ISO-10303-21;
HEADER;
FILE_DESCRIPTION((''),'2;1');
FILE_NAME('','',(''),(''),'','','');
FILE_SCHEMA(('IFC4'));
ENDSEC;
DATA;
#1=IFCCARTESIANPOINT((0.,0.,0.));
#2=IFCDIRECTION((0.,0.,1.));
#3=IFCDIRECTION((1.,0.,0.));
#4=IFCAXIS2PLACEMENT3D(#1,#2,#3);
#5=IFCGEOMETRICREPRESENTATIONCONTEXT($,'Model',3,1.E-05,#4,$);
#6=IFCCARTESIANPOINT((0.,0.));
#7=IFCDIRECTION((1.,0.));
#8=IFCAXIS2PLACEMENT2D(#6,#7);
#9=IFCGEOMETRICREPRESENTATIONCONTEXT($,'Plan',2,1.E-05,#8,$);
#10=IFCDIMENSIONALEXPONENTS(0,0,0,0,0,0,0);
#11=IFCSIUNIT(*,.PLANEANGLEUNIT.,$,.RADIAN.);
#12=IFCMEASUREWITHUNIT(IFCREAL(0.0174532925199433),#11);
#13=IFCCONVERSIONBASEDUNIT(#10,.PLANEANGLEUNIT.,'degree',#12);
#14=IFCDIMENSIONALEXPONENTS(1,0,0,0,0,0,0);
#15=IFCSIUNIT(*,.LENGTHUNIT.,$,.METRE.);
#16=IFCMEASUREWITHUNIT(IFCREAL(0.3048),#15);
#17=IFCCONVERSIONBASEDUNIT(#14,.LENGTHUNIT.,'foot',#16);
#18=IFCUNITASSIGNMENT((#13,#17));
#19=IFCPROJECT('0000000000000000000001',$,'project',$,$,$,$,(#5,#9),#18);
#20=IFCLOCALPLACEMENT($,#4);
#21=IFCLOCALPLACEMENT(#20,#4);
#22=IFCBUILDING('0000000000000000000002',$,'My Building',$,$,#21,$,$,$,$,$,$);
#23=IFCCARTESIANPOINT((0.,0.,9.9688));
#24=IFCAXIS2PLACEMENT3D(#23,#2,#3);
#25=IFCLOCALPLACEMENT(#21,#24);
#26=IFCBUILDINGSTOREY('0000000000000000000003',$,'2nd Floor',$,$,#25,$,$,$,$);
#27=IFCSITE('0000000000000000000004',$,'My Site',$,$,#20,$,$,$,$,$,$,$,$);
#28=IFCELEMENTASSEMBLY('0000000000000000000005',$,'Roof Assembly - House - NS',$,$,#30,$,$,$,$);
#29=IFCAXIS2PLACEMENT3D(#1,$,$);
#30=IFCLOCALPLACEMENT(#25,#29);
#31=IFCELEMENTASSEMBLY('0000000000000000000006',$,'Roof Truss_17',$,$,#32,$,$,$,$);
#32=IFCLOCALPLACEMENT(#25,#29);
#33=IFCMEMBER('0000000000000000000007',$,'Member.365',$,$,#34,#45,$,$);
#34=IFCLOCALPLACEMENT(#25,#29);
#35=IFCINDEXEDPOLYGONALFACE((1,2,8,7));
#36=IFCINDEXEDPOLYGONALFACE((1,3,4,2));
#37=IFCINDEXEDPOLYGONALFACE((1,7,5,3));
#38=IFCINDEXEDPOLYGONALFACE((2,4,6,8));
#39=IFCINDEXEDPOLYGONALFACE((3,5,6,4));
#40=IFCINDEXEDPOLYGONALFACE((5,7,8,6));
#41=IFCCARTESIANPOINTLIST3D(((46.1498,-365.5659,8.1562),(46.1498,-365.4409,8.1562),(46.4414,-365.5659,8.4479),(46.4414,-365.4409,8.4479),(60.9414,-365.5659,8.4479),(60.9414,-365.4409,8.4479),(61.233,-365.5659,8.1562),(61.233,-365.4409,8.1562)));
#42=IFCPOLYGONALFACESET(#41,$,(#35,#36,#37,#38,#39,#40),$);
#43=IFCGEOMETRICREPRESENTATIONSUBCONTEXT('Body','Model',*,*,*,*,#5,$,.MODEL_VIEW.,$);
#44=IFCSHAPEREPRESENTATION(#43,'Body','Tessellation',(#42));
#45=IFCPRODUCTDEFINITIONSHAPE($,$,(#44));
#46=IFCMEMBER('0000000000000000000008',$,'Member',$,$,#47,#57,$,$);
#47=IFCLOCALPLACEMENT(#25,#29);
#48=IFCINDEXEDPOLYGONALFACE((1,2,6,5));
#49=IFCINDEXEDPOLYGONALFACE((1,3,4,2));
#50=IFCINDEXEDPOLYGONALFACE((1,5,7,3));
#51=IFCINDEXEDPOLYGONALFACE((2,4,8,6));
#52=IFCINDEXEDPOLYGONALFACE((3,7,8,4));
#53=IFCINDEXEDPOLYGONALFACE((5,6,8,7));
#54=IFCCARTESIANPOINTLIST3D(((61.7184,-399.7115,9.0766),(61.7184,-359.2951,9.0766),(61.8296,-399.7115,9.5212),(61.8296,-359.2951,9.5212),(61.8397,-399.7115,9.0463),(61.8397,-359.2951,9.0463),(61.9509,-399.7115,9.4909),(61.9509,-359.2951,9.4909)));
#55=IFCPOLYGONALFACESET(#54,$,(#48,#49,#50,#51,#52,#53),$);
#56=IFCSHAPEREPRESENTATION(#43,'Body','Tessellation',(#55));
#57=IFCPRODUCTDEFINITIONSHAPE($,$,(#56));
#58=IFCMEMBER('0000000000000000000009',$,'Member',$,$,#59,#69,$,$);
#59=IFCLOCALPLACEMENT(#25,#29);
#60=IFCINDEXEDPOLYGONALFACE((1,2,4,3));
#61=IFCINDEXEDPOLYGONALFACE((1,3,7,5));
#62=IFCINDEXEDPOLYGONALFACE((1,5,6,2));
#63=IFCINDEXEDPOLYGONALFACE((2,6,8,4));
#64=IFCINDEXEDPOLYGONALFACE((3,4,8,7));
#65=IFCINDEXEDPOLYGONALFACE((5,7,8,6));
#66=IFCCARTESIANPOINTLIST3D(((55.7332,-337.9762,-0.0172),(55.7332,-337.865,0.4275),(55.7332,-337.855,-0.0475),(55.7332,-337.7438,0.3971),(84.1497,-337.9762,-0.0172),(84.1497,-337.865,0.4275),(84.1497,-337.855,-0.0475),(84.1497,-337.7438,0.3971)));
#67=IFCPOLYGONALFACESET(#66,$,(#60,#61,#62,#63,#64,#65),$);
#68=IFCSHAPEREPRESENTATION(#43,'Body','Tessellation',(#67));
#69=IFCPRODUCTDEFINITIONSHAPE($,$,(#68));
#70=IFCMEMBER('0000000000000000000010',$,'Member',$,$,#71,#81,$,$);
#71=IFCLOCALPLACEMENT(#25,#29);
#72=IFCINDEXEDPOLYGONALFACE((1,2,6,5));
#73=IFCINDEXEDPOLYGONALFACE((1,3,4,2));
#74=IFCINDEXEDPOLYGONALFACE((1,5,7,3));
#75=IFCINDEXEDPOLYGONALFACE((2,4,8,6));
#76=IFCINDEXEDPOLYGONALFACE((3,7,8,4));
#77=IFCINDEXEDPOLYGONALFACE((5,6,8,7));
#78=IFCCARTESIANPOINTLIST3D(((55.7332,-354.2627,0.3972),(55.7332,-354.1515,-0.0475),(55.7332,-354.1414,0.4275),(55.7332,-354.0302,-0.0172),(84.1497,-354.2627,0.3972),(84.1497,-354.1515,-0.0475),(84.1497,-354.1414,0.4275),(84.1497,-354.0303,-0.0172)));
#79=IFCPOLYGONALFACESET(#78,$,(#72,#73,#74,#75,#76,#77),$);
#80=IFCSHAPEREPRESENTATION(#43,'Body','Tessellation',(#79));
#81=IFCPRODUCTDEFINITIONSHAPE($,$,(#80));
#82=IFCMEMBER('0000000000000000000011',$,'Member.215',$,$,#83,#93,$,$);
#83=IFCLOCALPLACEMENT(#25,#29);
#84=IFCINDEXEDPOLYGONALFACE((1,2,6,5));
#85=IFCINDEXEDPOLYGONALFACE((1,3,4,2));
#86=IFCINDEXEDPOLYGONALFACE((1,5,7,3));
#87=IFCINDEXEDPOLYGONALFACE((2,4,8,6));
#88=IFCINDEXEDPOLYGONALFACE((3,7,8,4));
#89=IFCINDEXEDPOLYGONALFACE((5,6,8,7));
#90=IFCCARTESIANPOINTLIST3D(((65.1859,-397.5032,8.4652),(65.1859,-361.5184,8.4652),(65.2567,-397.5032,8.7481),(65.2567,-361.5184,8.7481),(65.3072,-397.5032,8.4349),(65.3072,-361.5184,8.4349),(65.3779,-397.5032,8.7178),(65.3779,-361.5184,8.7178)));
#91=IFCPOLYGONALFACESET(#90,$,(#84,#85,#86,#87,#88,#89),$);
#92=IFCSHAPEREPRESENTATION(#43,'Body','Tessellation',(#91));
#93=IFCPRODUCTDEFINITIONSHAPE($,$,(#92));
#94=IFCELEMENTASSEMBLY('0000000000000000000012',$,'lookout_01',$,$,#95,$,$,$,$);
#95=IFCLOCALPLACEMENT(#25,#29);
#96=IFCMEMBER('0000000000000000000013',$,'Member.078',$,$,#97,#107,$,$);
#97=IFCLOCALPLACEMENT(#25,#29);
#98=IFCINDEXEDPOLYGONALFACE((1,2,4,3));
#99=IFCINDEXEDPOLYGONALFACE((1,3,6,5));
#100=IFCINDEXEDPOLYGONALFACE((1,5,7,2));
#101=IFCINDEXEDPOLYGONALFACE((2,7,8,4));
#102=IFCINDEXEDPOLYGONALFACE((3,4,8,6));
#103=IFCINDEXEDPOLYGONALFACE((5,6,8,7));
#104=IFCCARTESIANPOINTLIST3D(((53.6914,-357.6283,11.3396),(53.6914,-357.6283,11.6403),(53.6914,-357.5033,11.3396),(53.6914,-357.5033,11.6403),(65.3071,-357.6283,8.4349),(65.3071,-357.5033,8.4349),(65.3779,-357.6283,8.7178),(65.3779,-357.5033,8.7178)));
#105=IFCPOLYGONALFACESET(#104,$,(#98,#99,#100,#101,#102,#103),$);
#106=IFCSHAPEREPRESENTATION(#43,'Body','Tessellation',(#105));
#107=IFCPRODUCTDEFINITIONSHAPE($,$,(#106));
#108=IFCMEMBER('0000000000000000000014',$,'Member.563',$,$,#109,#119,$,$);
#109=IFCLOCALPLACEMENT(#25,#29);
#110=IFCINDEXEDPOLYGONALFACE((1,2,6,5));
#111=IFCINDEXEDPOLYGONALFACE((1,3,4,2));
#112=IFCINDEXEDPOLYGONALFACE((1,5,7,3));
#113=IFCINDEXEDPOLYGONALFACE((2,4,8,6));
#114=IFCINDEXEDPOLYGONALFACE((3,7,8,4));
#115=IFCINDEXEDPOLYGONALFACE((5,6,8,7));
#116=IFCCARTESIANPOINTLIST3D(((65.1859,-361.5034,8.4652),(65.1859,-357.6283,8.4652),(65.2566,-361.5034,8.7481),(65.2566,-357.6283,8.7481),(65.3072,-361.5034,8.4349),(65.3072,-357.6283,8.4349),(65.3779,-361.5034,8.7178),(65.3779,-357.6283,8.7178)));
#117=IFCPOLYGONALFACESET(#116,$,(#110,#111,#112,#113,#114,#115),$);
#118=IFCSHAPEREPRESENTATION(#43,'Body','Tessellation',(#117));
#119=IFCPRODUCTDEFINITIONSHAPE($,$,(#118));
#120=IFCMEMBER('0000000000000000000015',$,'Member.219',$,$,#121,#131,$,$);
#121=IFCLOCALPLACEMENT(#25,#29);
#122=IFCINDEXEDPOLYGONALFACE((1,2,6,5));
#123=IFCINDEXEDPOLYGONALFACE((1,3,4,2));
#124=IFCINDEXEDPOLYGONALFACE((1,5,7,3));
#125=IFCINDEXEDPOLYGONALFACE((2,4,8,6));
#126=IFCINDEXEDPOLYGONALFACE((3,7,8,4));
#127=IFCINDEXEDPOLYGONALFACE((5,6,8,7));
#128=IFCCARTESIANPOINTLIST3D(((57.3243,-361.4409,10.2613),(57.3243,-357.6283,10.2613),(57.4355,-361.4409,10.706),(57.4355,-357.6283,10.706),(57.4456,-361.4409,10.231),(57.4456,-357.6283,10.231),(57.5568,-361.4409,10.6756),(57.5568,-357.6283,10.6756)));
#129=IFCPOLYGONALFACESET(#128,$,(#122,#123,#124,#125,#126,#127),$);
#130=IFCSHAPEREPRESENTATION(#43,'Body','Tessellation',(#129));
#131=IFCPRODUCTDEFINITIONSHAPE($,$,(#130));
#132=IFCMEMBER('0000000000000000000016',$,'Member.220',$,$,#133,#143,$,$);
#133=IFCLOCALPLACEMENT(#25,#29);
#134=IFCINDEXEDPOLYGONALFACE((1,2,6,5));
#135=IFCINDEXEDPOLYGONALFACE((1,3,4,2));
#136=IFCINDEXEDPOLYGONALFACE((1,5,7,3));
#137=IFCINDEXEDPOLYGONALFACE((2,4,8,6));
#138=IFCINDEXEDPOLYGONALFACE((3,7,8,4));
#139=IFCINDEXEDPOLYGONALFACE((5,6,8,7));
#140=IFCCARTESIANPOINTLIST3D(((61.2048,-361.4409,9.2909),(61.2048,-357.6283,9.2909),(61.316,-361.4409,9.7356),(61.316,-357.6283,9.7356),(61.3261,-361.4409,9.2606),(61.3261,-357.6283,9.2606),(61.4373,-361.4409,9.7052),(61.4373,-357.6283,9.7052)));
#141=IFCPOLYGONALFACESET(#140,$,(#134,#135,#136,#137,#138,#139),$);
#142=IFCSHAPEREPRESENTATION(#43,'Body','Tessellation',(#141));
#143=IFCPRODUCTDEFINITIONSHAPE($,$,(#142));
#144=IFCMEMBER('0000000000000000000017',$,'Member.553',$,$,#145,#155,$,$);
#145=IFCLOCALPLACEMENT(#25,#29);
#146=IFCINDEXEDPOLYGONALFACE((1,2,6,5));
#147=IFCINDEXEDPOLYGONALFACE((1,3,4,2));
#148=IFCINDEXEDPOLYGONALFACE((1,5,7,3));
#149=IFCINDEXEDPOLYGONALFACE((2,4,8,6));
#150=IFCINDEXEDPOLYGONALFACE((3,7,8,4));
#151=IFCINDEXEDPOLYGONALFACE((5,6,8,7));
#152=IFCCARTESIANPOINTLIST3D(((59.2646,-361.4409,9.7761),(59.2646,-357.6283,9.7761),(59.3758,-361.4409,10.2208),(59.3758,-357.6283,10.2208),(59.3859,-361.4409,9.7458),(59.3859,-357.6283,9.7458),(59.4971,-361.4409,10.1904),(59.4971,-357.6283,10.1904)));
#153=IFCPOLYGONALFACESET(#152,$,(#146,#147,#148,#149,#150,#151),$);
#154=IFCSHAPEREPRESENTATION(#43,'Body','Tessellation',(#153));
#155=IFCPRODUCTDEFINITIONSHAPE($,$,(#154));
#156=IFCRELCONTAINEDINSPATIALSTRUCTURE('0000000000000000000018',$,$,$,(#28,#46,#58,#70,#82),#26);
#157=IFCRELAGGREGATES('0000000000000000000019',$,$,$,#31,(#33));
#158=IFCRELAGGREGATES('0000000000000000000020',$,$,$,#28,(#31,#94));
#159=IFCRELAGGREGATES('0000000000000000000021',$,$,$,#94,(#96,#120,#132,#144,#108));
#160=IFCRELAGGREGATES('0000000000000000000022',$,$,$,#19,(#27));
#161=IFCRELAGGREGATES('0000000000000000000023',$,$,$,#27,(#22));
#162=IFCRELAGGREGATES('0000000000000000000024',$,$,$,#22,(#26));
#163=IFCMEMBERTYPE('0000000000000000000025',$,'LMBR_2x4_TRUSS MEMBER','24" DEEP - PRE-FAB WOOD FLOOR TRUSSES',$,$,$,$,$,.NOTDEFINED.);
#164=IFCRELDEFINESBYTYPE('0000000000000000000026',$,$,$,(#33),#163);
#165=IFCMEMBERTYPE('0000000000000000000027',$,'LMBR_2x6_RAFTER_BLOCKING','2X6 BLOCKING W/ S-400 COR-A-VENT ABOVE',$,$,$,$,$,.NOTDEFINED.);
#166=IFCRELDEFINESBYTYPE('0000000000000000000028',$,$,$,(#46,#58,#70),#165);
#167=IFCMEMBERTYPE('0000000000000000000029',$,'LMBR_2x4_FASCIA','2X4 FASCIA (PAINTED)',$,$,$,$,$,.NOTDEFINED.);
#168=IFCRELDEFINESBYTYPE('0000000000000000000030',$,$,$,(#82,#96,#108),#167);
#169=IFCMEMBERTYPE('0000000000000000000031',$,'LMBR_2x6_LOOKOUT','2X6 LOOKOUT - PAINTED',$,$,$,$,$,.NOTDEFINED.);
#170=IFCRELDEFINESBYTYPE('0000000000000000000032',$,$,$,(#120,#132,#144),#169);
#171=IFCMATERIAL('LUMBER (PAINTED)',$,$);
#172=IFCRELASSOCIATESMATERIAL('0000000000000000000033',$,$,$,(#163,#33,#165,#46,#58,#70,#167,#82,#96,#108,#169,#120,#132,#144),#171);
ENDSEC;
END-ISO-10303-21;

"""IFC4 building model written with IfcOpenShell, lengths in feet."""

from ifc_helpers import new_model, entity, si_unit, converted_unit, frame, origin_with_axes, origin_2d_with_axis, place, context, subcontext, project, spatial, indexed_curve, outline, extrude, clip, halfspace, material, material_profile, profile_set, profile_usage, type_object, element, aggregate, save


model = new_model("IFC4")

# Units and contexts
model_context = context("Model", 3, precision=1e-05, world=origin_with_axes())
plan_context = context("Plan", 2, precision=1e-05, world=origin_2d_with_axis())
body_context = subcontext(model_context, "Body", "Model", "MODEL_VIEW")
ifc_project = project(units=[converted_unit("PLANEANGLEUNIT", "degree", entity("IfcReal", 0.0174532925199433), si_unit("PLANEANGLEUNIT", "RADIAN"), dimensions=[0, 0, 0, 0, 0, 0, 0]), converted_unit("LENGTHUNIT", "foot", entity("IfcReal", 0.3048), si_unit("LENGTHUNIT", "METRE"), dimensions=[1, 0, 0, 0, 0, 0, 0])], contexts=[model_context, plan_context])

# Site, building, storey
site_placement = place(None, origin_with_axes())
site = spatial("IfcSite", under=ifc_project, at=site_placement, Name="My Site")
building_placement = place(site_placement, origin_with_axes())
building = spatial("IfcBuilding", under=site, at=building_placement, Name="My Building")
storey_placement = place(building_placement, frame((0.0, 0.0, 9.9688), z_axis=(0.0, 0.0, 1.0), x_axis=(1.0, 0.0, 0.0)))
storey = spatial("IfcBuildingStorey", under=building, at=storey_placement, Name="2nd Floor")

# Shared definitions
ifc_material_1 = material(Name="LUMBER (PAINTED)")

# Element assemblies, member
assembly_1_placement = place(storey_placement, frame((0.0, 0.0, -9.9688), z_axis=(0.0, 0.0, 1.0), x_axis=(1.0, 0.0, 0.0)))
assembly_1 = element("IfcElementAssembly", 1, at=assembly_1_placement, inside=storey, Name="Roof Assembly - House - NS")
ifc_material_profile_1 = material_profile(ifc_material_1, outline(indexed_curve([(-0.0625, -0.1458), (0.0625, -0.1458), (0.0625, 0.1458), (-0.0625, 0.1458), (-0.0625, -0.1458)])))
ifc_profile_set_1 = profile_set([ifc_material_profile_1])
member_type_1 = type_object("IfcMemberType", Name="LMBR_2x4_TRUSS MEMBER", Description="24\" DEEP - PRE-FAB WOOD FLOOR TRUSSES", PredefinedType="NOTDEFINED", material=ifc_profile_set_1)
assembly_2_placement = place(assembly_1_placement, frame((53.6914, -365.5034, 21.6754), z_axis=(0.0, 0.0, 1.0), x_axis=(1.0, 0.0, 0.0)))
assembly_2 = element("IfcElementAssembly", 2, at=assembly_2_placement, Name="Roof Truss_17")
ifc_profile_usage_1 = profile_usage(ifc_profile_set_1)
member_1_placement = place(assembly_2_placement, frame((7.5416, 0.0, -3.4046), z_axis=(-1.0, 0.0, 0.0), x_axis=(0.0, 1.0, 0.0)))
member_1 = element("IfcMember", 3, at=member_1_placement, type_object=member_type_1, material=ifc_profile_usage_1, Name="Member.365", context=body_context, shape_type="Clipping", body=[
    clip(clip(extrude(outline(indexed_curve([(-0.0625, -0.1458), (0.0625, -0.1458), (0.0625, 0.1458), (-0.0625, 0.1458), (-0.0625, -0.1458)])), origin_with_axes(), (0.0, 0.0, 1.0), 15.0833), halfspace(frame((397.5032, 0.1458, 0.0001), z_axis=(0.0, -0.707114, -0.707099), x_axis=(-1.0, 0.0, 0.0)), False)), halfspace(frame((397.5032, 0.1458, 15.0832), z_axis=(0.0, -0.707107, 0.707107), x_axis=(-1.0, 0.0, 0.0)), False)),
])
aggregate(assembly_2, [member_1])

# Members
ifc_material_profile_2 = material_profile(ifc_material_1, outline(indexed_curve([(-0.0625, 0.2292), (0.0625, 0.2292), (0.0625, -0.2292), (-0.0625, -0.2292), (-0.0625, 0.2292)])))
ifc_profile_set_2 = profile_set([ifc_material_profile_2])
ifc_profile_usage_2 = profile_usage(ifc_profile_set_2)
member_type_2 = type_object("IfcMemberType", Name="LMBR_2x6_RAFTER_BLOCKING", Description="2X6 BLOCKING W/ S-400 COR-A-VENT ABOVE", PredefinedType="NOTDEFINED", material=ifc_profile_set_2)
member_2_placement = place(storey_placement, frame((61.8346, -359.2951, 9.2838), z_axis=(0.0, -1.0, 0.0), x_axis=(0.970127, 0.0, -0.242599)))
element("IfcMember", 4, at=member_2_placement, inside=storey, type_object=member_type_2, material=ifc_profile_usage_2, Name="Member", context=body_context, shape_type="SweptSolid", body=[
    extrude(outline(indexed_curve([(-0.0625, 0.2292), (0.0625, 0.2292), (0.0625, -0.2292), (-0.0625, -0.2292), (-0.0625, 0.2292)])), origin_with_axes(), (0.0, 0.0, 1.0), 40.4164),
])
ifc_profile_usage_3 = profile_usage(ifc_profile_set_2)
member_3_placement = place(storey_placement, frame((84.1497, -337.86, 0.19), z_axis=(-1.0, 0.0, 0.0), x_axis=(0.0, -0.970127, 0.242599)))
element("IfcMember", 5, at=member_3_placement, inside=storey, type_object=member_type_2, material=ifc_profile_usage_3, Name="Member", context=body_context, shape_type="SweptSolid", body=[
    extrude(outline(indexed_curve([(-0.0625, 0.2292), (0.0625, 0.2292), (0.0625, -0.2292), (-0.0625, -0.2292), (-0.0625, 0.2292)])), origin_with_axes(), (0.0, 0.0, 1.0), 28.4166),
])
ifc_profile_usage_4 = profile_usage(ifc_profile_set_2)
member_4_placement = place(storey_placement, frame((84.1497, -354.1465, 0.19), z_axis=(-1.0, 0.0, 0.0), x_axis=(0.0, -0.970127, -0.242599)))
element("IfcMember", 6, at=member_4_placement, inside=storey, type_object=member_type_2, material=ifc_profile_usage_4, Name="Member", context=body_context, shape_type="SweptSolid", body=[
    extrude(outline(indexed_curve([(-0.0625, 0.2292), (0.0625, 0.2292), (0.0625, -0.2292), (-0.0625, -0.2292), (-0.0625, 0.2292)])), origin_with_axes(), (0.0, 0.0, 1.0), 28.4166),
])
ifc_material_profile_3 = material_profile(ifc_material_1, outline(indexed_curve([(-0.0625, -0.1458), (0.0625, -0.1458), (0.0625, 0.1458), (-0.0625, 0.1458), (-0.0625, -0.1458)])))
ifc_profile_set_3 = profile_set([ifc_material_profile_3])
ifc_profile_usage_5 = profile_usage(ifc_profile_set_3)
member_type_3 = type_object("IfcMemberType", Name="LMBR_2x4_FASCIA", Description="2X4 FASCIA (PAINTED)", PredefinedType="NOTDEFINED", material=ifc_profile_set_3)
member_5_placement = place(storey_placement, frame((65.2819, -361.5184, 8.5915), z_axis=(0.0, -1.0, 0.0), x_axis=(0.970127, 0.0, -0.242599)))
element("IfcMember", 7, at=member_5_placement, inside=storey, type_object=member_type_3, material=ifc_profile_usage_5, Name="Member.215", context=body_context, shape_type="SweptSolid", body=[
    extrude(outline(indexed_curve([(-0.0625, -0.1458), (0.0625, -0.1458), (0.0625, 0.1458), (-0.0625, 0.1458), (-0.0625, -0.1458)])), origin_with_axes(), (0.0, 0.0, 1.0), 35.9848),
])

# Element assembly
assembly_3_placement = place(assembly_1_placement, frame((53.6914, -361.5034, 21.6754), z_axis=(0.0, 0.0, 1.0), x_axis=(1.0, 0.0, 0.0)))
assembly_3 = element("IfcElementAssembly", 8, at=assembly_3_placement, Name="lookout_01")
aggregate(assembly_1, [assembly_2, assembly_3])

# Members
ifc_profile_usage_6 = profile_usage(ifc_profile_set_3)
member_6_placement = place(assembly_3_placement, frame((11.6511, 3.9375, -3.1303), z_axis=(-0.970127, 0.0, 0.242599), x_axis=(0.0, -1.0, 0.0)))
member_6 = element("IfcMember", 9, at=member_6_placement, type_object=member_type_3, material=ifc_profile_usage_6, Name="Member.078", context=body_context, shape_type="Clipping", body=[
    clip(extrude(outline(indexed_curve([(-0.0625, -0.1458), (0.0625, -0.1458), (0.0625, 0.1458), (-0.0625, 0.1458), (-0.0625, -0.1458)])), origin_with_axes(), (0.0, 0.0, 1.0), 12.6114), halfspace(frame((85.8788, 0.1458, 12.0464), z_axis=(0.0, -0.242599, 0.970127), x_axis=(-1.0, -0.000001, 0.0)), False)),
])
ifc_profile_usage_7 = profile_usage(ifc_profile_set_3)
member_7_placement = place(assembly_3_placement, frame((11.5905, 0.0, -3.1152), z_axis=(0.0, 1.0, 0.0), x_axis=(-0.970127, 0.0, 0.242599)))
member_7 = element("IfcMember", 10, at=member_7_placement, type_object=member_type_3, material=ifc_profile_usage_7, Name="Member.563", context=body_context, shape_type="SweptSolid", body=[
    extrude(outline(indexed_curve([(-0.0625, -0.1458), (0.0625, -0.1458), (0.0625, 0.1458), (-0.0625, 0.1458), (-0.0625, -0.1458)])), origin_with_axes(), (0.0, 0.0, 1.0), 3.875),
])
ifc_material_profile_4 = material_profile(ifc_material_1, outline(indexed_curve([(-0.0625, 0.2292), (0.0625, 0.2292), (0.0625, -0.2292), (-0.0625, -0.2292), (-0.0625, 0.2292)])))
ifc_profile_set_4 = profile_set([ifc_material_profile_4])
ifc_profile_usage_8 = profile_usage(ifc_profile_set_4)
member_type_4 = type_object("IfcMemberType", Name="LMBR_2x6_LOOKOUT", Description="2X6 LOOKOUT - PAINTED", PredefinedType="NOTDEFINED", material=ifc_profile_set_4)
member_8_placement = place(assembly_3_placement, frame((3.7491, 0.0625, -1.2382), z_axis=(0.0, 1.0, 0.0), x_axis=(-0.970127, 0.0, 0.242599)))
member_8 = element("IfcMember", 11, at=member_8_placement, type_object=member_type_4, material=ifc_profile_usage_8, Name="Member.219", context=body_context, shape_type="SweptSolid", body=[
    extrude(outline(indexed_curve([(-0.0625, 0.2292), (0.0625, 0.2292), (0.0625, -0.2292), (-0.0625, -0.2292), (-0.0625, 0.2292)])), origin_with_axes(), (0.0, 0.0, 1.0), 3.8125),
])
ifc_profile_usage_9 = profile_usage(ifc_profile_set_4)
member_9_placement = place(assembly_3_placement, frame((7.6296, 0.0625, -2.2086), z_axis=(0.0, 1.0, 0.0), x_axis=(-0.970127, 0.0, 0.242599)))
member_9 = element("IfcMember", 12, at=member_9_placement, type_object=member_type_4, material=ifc_profile_usage_9, Name="Member.220", context=body_context, shape_type="SweptSolid", body=[
    extrude(outline(indexed_curve([(-0.0625, 0.2292), (0.0625, 0.2292), (0.0625, -0.2292), (-0.0625, -0.2292), (-0.0625, 0.2292)])), origin_with_axes(), (0.0, 0.0, 1.0), 3.8125),
])
ifc_profile_usage_10 = profile_usage(ifc_profile_set_4)
member_10_placement = place(assembly_3_placement, frame((5.6894, 0.0625, -1.7234), z_axis=(0.0, 1.0, 0.0), x_axis=(-0.970127, 0.0, 0.242599)))
member_10 = element("IfcMember", 13, at=member_10_placement, type_object=member_type_4, material=ifc_profile_usage_10, Name="Member.553", context=body_context, shape_type="SweptSolid", body=[
    extrude(outline(indexed_curve([(-0.0625, 0.2292), (0.0625, 0.2292), (0.0625, -0.2292), (-0.0625, -0.2292), (-0.0625, 0.2292)])), origin_with_axes(), (0.0, 0.0, 1.0), 3.8125),
])
aggregate(assembly_3, [member_6, member_8, member_9, member_10, member_7])

save(model, "model.ifc")
